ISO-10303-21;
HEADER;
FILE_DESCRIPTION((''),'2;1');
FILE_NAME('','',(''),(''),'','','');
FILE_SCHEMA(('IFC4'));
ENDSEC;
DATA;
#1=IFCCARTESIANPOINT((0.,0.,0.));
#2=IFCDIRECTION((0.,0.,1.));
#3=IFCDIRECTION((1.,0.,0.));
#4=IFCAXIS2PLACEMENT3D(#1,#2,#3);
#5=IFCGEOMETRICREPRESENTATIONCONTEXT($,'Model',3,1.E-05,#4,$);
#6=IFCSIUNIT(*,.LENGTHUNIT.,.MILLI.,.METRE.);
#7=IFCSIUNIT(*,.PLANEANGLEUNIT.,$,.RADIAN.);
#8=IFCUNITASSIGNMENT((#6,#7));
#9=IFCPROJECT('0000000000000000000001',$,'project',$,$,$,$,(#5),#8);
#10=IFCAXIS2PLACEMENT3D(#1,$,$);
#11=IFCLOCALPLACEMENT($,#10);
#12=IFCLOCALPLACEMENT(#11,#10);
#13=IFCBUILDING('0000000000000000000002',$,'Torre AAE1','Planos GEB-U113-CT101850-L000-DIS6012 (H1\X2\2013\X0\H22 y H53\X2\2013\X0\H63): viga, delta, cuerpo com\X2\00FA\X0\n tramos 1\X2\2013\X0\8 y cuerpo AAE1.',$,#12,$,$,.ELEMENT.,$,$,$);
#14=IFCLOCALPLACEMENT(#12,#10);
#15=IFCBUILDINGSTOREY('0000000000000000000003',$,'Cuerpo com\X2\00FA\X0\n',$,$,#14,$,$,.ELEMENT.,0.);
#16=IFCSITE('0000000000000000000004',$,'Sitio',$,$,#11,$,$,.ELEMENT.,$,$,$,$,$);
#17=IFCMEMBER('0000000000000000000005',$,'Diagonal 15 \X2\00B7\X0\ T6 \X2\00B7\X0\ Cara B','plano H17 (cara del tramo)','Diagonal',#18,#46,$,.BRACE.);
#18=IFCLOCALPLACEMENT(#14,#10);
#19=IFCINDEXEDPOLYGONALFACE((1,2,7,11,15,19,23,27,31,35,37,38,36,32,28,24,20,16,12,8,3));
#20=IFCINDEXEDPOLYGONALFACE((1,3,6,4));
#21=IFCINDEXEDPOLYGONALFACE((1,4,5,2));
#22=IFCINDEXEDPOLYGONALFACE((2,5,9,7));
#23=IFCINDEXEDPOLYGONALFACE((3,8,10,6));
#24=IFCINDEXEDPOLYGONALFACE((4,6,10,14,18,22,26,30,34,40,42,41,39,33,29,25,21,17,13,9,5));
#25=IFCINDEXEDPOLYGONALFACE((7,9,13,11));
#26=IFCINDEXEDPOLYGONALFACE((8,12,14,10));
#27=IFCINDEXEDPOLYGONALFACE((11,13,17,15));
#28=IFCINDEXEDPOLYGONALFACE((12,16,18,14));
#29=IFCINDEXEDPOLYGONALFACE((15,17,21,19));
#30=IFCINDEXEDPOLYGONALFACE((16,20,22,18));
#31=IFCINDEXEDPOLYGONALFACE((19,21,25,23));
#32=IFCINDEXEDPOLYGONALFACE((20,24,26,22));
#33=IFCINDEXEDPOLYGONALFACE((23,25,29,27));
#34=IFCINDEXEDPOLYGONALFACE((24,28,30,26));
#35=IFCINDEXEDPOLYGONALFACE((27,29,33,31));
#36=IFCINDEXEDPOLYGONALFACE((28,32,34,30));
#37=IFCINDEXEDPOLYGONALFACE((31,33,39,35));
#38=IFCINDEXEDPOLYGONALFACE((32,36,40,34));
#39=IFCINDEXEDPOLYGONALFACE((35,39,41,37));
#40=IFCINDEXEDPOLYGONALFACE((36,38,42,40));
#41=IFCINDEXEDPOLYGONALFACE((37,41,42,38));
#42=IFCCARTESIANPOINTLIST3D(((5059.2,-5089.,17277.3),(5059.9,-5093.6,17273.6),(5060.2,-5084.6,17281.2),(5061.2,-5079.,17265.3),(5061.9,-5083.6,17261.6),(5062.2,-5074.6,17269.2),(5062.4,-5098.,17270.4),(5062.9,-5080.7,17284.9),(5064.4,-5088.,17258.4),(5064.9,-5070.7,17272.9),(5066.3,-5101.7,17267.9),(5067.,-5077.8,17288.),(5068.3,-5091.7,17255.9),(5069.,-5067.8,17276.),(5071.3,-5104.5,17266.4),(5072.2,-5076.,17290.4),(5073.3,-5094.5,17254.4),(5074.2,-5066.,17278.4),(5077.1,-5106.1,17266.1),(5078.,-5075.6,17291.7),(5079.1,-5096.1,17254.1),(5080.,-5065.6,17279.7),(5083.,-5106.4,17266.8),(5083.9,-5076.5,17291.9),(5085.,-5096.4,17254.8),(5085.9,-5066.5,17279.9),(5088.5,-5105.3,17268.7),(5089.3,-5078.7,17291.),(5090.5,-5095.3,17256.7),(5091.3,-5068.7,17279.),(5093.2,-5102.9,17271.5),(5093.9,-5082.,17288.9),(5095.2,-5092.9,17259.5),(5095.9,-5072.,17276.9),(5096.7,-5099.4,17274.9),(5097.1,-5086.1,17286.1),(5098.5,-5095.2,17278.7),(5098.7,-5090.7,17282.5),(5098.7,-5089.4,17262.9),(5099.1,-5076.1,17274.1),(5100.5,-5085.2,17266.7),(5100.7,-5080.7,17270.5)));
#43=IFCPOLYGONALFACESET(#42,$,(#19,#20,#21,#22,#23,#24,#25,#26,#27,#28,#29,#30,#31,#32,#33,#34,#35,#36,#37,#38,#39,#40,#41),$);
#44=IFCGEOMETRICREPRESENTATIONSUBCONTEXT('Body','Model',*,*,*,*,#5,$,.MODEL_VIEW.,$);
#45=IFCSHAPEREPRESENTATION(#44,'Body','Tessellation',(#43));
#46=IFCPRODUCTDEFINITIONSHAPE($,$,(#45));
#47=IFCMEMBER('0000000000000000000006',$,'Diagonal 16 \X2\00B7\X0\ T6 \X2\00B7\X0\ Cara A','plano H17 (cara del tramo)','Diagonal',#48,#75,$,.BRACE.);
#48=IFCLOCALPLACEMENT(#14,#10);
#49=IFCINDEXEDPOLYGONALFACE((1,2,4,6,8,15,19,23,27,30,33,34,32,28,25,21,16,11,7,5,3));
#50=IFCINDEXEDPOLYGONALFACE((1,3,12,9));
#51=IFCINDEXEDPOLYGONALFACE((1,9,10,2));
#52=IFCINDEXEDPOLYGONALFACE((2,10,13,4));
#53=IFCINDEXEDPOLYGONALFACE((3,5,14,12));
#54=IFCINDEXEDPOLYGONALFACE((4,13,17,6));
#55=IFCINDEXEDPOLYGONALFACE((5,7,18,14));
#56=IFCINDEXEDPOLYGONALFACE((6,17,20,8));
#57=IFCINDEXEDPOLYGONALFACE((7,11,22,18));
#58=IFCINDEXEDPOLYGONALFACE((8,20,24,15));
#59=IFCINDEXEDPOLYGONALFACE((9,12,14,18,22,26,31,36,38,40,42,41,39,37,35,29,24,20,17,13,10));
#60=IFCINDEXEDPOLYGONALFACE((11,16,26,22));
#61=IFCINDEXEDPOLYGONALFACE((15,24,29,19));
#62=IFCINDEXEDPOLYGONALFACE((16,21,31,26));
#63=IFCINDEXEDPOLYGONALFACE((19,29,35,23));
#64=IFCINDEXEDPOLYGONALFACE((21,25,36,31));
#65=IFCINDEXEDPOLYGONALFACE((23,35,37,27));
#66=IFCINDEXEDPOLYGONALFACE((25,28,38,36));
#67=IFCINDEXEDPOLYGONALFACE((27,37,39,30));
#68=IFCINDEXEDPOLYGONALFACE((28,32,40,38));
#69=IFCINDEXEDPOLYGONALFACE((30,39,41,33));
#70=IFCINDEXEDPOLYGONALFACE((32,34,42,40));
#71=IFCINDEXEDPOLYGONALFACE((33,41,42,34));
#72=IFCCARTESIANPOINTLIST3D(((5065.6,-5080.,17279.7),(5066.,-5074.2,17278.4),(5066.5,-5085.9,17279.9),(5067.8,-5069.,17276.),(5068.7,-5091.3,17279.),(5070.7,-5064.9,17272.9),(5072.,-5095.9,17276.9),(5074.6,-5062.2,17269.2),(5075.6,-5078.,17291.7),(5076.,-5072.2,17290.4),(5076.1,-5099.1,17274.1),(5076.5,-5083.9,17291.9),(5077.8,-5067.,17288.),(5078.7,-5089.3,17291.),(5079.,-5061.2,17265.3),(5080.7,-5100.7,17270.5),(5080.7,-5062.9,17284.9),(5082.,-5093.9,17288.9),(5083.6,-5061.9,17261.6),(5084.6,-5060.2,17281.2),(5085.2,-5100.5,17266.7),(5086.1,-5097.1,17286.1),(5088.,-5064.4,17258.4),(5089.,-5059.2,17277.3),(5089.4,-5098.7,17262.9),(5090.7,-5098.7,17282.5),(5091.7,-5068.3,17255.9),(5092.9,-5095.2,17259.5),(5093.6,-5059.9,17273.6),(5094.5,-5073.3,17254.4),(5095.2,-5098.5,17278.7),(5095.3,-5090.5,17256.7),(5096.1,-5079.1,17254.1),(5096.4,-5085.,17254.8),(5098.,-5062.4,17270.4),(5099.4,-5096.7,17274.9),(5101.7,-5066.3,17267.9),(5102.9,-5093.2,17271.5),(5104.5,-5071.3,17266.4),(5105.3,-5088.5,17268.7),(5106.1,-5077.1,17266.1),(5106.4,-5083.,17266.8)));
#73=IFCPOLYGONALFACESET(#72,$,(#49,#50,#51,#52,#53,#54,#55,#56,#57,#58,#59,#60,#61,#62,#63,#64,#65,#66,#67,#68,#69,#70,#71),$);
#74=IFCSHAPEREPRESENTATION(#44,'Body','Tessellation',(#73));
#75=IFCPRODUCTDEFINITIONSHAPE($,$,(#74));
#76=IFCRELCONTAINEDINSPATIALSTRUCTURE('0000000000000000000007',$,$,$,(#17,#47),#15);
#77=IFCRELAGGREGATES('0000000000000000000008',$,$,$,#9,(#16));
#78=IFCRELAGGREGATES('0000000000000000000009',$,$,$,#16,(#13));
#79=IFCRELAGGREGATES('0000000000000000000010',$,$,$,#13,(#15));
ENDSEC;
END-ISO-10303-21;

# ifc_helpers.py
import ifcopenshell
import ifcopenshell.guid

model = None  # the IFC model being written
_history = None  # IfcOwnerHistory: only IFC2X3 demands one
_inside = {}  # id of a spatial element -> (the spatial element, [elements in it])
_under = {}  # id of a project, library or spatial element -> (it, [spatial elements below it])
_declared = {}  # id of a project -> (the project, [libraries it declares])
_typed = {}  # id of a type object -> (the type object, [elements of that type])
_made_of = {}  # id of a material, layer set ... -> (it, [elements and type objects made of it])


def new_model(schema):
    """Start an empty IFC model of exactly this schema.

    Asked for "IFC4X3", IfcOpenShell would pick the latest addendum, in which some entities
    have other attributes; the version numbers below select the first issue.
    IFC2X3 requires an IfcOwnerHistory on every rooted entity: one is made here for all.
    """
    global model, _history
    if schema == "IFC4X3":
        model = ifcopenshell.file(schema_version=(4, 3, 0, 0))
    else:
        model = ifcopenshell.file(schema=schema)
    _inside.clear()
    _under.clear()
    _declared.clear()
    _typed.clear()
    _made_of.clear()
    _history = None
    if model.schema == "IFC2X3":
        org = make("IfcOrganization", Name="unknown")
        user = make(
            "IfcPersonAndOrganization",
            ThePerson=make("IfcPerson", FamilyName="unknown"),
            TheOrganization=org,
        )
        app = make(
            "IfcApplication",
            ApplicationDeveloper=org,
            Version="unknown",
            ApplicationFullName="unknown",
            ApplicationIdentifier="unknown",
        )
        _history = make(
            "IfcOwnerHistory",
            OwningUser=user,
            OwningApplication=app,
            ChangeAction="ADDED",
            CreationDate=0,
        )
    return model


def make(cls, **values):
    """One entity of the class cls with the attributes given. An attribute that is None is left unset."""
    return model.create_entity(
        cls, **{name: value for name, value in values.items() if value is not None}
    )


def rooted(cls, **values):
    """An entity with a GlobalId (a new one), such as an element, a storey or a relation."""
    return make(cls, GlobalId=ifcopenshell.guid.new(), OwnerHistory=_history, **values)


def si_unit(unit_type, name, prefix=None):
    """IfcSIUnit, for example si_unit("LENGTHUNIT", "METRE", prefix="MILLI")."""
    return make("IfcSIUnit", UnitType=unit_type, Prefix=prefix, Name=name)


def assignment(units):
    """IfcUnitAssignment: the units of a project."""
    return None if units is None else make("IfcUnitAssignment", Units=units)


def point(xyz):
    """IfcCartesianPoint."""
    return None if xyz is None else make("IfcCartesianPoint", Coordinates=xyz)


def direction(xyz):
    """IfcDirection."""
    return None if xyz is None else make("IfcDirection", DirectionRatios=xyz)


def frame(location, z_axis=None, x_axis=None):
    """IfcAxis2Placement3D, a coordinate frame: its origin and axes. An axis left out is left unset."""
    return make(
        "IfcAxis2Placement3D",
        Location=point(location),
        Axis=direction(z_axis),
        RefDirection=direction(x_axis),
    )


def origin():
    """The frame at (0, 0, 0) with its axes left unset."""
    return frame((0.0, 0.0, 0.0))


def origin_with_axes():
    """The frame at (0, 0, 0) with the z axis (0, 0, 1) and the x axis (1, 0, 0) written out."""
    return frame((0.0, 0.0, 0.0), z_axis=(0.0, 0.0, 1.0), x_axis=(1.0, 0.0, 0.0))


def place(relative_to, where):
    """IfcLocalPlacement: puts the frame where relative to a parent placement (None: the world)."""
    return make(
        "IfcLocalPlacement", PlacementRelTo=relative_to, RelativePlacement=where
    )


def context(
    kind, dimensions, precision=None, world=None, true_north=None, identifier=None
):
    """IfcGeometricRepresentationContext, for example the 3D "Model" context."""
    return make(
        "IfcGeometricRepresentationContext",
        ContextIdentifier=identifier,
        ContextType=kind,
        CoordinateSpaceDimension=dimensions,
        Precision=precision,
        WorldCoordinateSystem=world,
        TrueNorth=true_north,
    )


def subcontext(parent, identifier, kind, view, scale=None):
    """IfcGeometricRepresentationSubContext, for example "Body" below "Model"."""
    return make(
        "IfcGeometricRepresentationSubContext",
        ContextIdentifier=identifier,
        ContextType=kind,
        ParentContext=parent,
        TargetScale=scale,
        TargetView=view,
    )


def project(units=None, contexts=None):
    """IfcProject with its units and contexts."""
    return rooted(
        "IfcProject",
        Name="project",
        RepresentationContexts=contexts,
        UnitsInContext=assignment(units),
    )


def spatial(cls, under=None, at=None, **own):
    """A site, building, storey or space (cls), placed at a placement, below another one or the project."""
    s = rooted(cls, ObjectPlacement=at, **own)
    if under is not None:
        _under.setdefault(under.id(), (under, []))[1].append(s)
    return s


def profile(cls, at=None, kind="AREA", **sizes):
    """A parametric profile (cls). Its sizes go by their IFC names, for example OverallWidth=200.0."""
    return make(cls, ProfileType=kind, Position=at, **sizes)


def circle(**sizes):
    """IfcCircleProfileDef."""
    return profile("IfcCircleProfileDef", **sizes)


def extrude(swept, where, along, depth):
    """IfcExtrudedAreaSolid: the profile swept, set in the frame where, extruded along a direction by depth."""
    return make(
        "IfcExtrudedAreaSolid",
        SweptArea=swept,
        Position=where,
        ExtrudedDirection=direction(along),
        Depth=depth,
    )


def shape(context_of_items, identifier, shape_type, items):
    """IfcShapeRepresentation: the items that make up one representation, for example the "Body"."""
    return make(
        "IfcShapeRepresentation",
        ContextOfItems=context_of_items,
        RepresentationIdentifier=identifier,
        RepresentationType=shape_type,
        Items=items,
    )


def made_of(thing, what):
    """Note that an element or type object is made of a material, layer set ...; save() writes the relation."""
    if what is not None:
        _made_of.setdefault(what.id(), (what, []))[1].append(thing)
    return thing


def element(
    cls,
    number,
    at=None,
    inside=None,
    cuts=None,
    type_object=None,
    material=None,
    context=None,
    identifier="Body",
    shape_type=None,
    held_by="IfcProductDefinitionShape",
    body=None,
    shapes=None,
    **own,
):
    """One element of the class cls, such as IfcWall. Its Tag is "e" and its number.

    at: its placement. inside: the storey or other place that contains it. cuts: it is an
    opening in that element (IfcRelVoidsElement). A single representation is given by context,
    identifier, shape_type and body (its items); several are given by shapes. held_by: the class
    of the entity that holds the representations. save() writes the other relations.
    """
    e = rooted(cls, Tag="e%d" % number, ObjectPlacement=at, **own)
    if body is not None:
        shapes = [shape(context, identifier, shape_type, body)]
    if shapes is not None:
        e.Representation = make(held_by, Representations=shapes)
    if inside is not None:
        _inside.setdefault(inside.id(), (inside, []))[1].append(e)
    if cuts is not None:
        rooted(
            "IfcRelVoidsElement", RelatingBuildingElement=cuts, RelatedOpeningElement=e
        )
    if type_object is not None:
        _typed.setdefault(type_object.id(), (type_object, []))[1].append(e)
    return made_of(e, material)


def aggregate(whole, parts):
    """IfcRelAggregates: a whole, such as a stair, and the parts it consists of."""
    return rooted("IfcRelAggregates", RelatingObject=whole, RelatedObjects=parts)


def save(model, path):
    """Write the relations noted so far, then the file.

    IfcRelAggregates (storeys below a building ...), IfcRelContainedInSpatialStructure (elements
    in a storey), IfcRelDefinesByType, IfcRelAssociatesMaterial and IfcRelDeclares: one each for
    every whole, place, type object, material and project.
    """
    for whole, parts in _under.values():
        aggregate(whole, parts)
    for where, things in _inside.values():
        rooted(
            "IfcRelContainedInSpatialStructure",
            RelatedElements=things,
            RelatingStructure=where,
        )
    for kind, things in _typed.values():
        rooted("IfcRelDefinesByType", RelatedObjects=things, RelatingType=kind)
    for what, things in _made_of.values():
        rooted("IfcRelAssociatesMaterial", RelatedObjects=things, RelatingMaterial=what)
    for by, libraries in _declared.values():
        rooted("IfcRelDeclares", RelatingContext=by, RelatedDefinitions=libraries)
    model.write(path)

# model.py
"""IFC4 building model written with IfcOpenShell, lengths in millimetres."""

from ifc_helpers import new_model, si_unit, frame, origin, origin_with_axes, place, context, subcontext, project, spatial, circle, extrude, element, save


model = new_model("IFC4")

# Units and contexts
model_context = context("Model", 3, precision=1e-05, world=origin_with_axes())
body_context = subcontext(model_context, "Body", "Model", "MODEL_VIEW")
ifc_project = project(units=[si_unit("LENGTHUNIT", "METRE", prefix="MILLI"), si_unit("PLANEANGLEUNIT", "RADIAN")], contexts=[model_context])

# Site, building, storey
site_placement = place(None, origin())
site = spatial("IfcSite", under=ifc_project, at=site_placement, Name="Sitio", CompositionType="ELEMENT")
building_placement = place(site_placement, origin())
building = spatial("IfcBuilding", under=site, at=building_placement, Name="Torre AAE1", Description="Planos GEB-U113-CT101850-L000-DIS6012 (H1–H22 y H53–H63): viga, delta, cuerpo común tramos 1–8 y cuerpo AAE1.", CompositionType="ELEMENT")
storey_placement = place(building_placement, origin())
storey = spatial("IfcBuildingStorey", under=building, at=storey_placement, Name="Cuerpo común", CompositionType="ELEMENT", Elevation=0.0)

# Members
for number, where, z_axis, x_axis, name in (
    (1, (5079.0, -5091.0, 17279.0), (0.127, 0.635001, -0.762001), (-0.806261, 0.513563, 0.293592), "Diagonal 15 · T6 · Cara B"),
    (2, (5091.0, -5079.0, 17279.0), (-0.635001, -0.127, -0.762001), (-0.513563, 0.806261, 0.293592), "Diagonal 16 · T6 · Cara A"),
):
    element("IfcMember", number, at=place(storey_placement, frame(where, z_axis=z_axis, x_axis=x_axis)), inside=storey, Name=name, Description="plano H17 (cara del tramo)", ObjectType="Diagonal", PredefinedType="BRACE", context=body_context, shape_type="SweptSolid", body=[
        extrude(circle(Radius=20.0), None, (0.0, 0.0, 1.0), 15.7),
    ])

save(model, "model.ifc")
